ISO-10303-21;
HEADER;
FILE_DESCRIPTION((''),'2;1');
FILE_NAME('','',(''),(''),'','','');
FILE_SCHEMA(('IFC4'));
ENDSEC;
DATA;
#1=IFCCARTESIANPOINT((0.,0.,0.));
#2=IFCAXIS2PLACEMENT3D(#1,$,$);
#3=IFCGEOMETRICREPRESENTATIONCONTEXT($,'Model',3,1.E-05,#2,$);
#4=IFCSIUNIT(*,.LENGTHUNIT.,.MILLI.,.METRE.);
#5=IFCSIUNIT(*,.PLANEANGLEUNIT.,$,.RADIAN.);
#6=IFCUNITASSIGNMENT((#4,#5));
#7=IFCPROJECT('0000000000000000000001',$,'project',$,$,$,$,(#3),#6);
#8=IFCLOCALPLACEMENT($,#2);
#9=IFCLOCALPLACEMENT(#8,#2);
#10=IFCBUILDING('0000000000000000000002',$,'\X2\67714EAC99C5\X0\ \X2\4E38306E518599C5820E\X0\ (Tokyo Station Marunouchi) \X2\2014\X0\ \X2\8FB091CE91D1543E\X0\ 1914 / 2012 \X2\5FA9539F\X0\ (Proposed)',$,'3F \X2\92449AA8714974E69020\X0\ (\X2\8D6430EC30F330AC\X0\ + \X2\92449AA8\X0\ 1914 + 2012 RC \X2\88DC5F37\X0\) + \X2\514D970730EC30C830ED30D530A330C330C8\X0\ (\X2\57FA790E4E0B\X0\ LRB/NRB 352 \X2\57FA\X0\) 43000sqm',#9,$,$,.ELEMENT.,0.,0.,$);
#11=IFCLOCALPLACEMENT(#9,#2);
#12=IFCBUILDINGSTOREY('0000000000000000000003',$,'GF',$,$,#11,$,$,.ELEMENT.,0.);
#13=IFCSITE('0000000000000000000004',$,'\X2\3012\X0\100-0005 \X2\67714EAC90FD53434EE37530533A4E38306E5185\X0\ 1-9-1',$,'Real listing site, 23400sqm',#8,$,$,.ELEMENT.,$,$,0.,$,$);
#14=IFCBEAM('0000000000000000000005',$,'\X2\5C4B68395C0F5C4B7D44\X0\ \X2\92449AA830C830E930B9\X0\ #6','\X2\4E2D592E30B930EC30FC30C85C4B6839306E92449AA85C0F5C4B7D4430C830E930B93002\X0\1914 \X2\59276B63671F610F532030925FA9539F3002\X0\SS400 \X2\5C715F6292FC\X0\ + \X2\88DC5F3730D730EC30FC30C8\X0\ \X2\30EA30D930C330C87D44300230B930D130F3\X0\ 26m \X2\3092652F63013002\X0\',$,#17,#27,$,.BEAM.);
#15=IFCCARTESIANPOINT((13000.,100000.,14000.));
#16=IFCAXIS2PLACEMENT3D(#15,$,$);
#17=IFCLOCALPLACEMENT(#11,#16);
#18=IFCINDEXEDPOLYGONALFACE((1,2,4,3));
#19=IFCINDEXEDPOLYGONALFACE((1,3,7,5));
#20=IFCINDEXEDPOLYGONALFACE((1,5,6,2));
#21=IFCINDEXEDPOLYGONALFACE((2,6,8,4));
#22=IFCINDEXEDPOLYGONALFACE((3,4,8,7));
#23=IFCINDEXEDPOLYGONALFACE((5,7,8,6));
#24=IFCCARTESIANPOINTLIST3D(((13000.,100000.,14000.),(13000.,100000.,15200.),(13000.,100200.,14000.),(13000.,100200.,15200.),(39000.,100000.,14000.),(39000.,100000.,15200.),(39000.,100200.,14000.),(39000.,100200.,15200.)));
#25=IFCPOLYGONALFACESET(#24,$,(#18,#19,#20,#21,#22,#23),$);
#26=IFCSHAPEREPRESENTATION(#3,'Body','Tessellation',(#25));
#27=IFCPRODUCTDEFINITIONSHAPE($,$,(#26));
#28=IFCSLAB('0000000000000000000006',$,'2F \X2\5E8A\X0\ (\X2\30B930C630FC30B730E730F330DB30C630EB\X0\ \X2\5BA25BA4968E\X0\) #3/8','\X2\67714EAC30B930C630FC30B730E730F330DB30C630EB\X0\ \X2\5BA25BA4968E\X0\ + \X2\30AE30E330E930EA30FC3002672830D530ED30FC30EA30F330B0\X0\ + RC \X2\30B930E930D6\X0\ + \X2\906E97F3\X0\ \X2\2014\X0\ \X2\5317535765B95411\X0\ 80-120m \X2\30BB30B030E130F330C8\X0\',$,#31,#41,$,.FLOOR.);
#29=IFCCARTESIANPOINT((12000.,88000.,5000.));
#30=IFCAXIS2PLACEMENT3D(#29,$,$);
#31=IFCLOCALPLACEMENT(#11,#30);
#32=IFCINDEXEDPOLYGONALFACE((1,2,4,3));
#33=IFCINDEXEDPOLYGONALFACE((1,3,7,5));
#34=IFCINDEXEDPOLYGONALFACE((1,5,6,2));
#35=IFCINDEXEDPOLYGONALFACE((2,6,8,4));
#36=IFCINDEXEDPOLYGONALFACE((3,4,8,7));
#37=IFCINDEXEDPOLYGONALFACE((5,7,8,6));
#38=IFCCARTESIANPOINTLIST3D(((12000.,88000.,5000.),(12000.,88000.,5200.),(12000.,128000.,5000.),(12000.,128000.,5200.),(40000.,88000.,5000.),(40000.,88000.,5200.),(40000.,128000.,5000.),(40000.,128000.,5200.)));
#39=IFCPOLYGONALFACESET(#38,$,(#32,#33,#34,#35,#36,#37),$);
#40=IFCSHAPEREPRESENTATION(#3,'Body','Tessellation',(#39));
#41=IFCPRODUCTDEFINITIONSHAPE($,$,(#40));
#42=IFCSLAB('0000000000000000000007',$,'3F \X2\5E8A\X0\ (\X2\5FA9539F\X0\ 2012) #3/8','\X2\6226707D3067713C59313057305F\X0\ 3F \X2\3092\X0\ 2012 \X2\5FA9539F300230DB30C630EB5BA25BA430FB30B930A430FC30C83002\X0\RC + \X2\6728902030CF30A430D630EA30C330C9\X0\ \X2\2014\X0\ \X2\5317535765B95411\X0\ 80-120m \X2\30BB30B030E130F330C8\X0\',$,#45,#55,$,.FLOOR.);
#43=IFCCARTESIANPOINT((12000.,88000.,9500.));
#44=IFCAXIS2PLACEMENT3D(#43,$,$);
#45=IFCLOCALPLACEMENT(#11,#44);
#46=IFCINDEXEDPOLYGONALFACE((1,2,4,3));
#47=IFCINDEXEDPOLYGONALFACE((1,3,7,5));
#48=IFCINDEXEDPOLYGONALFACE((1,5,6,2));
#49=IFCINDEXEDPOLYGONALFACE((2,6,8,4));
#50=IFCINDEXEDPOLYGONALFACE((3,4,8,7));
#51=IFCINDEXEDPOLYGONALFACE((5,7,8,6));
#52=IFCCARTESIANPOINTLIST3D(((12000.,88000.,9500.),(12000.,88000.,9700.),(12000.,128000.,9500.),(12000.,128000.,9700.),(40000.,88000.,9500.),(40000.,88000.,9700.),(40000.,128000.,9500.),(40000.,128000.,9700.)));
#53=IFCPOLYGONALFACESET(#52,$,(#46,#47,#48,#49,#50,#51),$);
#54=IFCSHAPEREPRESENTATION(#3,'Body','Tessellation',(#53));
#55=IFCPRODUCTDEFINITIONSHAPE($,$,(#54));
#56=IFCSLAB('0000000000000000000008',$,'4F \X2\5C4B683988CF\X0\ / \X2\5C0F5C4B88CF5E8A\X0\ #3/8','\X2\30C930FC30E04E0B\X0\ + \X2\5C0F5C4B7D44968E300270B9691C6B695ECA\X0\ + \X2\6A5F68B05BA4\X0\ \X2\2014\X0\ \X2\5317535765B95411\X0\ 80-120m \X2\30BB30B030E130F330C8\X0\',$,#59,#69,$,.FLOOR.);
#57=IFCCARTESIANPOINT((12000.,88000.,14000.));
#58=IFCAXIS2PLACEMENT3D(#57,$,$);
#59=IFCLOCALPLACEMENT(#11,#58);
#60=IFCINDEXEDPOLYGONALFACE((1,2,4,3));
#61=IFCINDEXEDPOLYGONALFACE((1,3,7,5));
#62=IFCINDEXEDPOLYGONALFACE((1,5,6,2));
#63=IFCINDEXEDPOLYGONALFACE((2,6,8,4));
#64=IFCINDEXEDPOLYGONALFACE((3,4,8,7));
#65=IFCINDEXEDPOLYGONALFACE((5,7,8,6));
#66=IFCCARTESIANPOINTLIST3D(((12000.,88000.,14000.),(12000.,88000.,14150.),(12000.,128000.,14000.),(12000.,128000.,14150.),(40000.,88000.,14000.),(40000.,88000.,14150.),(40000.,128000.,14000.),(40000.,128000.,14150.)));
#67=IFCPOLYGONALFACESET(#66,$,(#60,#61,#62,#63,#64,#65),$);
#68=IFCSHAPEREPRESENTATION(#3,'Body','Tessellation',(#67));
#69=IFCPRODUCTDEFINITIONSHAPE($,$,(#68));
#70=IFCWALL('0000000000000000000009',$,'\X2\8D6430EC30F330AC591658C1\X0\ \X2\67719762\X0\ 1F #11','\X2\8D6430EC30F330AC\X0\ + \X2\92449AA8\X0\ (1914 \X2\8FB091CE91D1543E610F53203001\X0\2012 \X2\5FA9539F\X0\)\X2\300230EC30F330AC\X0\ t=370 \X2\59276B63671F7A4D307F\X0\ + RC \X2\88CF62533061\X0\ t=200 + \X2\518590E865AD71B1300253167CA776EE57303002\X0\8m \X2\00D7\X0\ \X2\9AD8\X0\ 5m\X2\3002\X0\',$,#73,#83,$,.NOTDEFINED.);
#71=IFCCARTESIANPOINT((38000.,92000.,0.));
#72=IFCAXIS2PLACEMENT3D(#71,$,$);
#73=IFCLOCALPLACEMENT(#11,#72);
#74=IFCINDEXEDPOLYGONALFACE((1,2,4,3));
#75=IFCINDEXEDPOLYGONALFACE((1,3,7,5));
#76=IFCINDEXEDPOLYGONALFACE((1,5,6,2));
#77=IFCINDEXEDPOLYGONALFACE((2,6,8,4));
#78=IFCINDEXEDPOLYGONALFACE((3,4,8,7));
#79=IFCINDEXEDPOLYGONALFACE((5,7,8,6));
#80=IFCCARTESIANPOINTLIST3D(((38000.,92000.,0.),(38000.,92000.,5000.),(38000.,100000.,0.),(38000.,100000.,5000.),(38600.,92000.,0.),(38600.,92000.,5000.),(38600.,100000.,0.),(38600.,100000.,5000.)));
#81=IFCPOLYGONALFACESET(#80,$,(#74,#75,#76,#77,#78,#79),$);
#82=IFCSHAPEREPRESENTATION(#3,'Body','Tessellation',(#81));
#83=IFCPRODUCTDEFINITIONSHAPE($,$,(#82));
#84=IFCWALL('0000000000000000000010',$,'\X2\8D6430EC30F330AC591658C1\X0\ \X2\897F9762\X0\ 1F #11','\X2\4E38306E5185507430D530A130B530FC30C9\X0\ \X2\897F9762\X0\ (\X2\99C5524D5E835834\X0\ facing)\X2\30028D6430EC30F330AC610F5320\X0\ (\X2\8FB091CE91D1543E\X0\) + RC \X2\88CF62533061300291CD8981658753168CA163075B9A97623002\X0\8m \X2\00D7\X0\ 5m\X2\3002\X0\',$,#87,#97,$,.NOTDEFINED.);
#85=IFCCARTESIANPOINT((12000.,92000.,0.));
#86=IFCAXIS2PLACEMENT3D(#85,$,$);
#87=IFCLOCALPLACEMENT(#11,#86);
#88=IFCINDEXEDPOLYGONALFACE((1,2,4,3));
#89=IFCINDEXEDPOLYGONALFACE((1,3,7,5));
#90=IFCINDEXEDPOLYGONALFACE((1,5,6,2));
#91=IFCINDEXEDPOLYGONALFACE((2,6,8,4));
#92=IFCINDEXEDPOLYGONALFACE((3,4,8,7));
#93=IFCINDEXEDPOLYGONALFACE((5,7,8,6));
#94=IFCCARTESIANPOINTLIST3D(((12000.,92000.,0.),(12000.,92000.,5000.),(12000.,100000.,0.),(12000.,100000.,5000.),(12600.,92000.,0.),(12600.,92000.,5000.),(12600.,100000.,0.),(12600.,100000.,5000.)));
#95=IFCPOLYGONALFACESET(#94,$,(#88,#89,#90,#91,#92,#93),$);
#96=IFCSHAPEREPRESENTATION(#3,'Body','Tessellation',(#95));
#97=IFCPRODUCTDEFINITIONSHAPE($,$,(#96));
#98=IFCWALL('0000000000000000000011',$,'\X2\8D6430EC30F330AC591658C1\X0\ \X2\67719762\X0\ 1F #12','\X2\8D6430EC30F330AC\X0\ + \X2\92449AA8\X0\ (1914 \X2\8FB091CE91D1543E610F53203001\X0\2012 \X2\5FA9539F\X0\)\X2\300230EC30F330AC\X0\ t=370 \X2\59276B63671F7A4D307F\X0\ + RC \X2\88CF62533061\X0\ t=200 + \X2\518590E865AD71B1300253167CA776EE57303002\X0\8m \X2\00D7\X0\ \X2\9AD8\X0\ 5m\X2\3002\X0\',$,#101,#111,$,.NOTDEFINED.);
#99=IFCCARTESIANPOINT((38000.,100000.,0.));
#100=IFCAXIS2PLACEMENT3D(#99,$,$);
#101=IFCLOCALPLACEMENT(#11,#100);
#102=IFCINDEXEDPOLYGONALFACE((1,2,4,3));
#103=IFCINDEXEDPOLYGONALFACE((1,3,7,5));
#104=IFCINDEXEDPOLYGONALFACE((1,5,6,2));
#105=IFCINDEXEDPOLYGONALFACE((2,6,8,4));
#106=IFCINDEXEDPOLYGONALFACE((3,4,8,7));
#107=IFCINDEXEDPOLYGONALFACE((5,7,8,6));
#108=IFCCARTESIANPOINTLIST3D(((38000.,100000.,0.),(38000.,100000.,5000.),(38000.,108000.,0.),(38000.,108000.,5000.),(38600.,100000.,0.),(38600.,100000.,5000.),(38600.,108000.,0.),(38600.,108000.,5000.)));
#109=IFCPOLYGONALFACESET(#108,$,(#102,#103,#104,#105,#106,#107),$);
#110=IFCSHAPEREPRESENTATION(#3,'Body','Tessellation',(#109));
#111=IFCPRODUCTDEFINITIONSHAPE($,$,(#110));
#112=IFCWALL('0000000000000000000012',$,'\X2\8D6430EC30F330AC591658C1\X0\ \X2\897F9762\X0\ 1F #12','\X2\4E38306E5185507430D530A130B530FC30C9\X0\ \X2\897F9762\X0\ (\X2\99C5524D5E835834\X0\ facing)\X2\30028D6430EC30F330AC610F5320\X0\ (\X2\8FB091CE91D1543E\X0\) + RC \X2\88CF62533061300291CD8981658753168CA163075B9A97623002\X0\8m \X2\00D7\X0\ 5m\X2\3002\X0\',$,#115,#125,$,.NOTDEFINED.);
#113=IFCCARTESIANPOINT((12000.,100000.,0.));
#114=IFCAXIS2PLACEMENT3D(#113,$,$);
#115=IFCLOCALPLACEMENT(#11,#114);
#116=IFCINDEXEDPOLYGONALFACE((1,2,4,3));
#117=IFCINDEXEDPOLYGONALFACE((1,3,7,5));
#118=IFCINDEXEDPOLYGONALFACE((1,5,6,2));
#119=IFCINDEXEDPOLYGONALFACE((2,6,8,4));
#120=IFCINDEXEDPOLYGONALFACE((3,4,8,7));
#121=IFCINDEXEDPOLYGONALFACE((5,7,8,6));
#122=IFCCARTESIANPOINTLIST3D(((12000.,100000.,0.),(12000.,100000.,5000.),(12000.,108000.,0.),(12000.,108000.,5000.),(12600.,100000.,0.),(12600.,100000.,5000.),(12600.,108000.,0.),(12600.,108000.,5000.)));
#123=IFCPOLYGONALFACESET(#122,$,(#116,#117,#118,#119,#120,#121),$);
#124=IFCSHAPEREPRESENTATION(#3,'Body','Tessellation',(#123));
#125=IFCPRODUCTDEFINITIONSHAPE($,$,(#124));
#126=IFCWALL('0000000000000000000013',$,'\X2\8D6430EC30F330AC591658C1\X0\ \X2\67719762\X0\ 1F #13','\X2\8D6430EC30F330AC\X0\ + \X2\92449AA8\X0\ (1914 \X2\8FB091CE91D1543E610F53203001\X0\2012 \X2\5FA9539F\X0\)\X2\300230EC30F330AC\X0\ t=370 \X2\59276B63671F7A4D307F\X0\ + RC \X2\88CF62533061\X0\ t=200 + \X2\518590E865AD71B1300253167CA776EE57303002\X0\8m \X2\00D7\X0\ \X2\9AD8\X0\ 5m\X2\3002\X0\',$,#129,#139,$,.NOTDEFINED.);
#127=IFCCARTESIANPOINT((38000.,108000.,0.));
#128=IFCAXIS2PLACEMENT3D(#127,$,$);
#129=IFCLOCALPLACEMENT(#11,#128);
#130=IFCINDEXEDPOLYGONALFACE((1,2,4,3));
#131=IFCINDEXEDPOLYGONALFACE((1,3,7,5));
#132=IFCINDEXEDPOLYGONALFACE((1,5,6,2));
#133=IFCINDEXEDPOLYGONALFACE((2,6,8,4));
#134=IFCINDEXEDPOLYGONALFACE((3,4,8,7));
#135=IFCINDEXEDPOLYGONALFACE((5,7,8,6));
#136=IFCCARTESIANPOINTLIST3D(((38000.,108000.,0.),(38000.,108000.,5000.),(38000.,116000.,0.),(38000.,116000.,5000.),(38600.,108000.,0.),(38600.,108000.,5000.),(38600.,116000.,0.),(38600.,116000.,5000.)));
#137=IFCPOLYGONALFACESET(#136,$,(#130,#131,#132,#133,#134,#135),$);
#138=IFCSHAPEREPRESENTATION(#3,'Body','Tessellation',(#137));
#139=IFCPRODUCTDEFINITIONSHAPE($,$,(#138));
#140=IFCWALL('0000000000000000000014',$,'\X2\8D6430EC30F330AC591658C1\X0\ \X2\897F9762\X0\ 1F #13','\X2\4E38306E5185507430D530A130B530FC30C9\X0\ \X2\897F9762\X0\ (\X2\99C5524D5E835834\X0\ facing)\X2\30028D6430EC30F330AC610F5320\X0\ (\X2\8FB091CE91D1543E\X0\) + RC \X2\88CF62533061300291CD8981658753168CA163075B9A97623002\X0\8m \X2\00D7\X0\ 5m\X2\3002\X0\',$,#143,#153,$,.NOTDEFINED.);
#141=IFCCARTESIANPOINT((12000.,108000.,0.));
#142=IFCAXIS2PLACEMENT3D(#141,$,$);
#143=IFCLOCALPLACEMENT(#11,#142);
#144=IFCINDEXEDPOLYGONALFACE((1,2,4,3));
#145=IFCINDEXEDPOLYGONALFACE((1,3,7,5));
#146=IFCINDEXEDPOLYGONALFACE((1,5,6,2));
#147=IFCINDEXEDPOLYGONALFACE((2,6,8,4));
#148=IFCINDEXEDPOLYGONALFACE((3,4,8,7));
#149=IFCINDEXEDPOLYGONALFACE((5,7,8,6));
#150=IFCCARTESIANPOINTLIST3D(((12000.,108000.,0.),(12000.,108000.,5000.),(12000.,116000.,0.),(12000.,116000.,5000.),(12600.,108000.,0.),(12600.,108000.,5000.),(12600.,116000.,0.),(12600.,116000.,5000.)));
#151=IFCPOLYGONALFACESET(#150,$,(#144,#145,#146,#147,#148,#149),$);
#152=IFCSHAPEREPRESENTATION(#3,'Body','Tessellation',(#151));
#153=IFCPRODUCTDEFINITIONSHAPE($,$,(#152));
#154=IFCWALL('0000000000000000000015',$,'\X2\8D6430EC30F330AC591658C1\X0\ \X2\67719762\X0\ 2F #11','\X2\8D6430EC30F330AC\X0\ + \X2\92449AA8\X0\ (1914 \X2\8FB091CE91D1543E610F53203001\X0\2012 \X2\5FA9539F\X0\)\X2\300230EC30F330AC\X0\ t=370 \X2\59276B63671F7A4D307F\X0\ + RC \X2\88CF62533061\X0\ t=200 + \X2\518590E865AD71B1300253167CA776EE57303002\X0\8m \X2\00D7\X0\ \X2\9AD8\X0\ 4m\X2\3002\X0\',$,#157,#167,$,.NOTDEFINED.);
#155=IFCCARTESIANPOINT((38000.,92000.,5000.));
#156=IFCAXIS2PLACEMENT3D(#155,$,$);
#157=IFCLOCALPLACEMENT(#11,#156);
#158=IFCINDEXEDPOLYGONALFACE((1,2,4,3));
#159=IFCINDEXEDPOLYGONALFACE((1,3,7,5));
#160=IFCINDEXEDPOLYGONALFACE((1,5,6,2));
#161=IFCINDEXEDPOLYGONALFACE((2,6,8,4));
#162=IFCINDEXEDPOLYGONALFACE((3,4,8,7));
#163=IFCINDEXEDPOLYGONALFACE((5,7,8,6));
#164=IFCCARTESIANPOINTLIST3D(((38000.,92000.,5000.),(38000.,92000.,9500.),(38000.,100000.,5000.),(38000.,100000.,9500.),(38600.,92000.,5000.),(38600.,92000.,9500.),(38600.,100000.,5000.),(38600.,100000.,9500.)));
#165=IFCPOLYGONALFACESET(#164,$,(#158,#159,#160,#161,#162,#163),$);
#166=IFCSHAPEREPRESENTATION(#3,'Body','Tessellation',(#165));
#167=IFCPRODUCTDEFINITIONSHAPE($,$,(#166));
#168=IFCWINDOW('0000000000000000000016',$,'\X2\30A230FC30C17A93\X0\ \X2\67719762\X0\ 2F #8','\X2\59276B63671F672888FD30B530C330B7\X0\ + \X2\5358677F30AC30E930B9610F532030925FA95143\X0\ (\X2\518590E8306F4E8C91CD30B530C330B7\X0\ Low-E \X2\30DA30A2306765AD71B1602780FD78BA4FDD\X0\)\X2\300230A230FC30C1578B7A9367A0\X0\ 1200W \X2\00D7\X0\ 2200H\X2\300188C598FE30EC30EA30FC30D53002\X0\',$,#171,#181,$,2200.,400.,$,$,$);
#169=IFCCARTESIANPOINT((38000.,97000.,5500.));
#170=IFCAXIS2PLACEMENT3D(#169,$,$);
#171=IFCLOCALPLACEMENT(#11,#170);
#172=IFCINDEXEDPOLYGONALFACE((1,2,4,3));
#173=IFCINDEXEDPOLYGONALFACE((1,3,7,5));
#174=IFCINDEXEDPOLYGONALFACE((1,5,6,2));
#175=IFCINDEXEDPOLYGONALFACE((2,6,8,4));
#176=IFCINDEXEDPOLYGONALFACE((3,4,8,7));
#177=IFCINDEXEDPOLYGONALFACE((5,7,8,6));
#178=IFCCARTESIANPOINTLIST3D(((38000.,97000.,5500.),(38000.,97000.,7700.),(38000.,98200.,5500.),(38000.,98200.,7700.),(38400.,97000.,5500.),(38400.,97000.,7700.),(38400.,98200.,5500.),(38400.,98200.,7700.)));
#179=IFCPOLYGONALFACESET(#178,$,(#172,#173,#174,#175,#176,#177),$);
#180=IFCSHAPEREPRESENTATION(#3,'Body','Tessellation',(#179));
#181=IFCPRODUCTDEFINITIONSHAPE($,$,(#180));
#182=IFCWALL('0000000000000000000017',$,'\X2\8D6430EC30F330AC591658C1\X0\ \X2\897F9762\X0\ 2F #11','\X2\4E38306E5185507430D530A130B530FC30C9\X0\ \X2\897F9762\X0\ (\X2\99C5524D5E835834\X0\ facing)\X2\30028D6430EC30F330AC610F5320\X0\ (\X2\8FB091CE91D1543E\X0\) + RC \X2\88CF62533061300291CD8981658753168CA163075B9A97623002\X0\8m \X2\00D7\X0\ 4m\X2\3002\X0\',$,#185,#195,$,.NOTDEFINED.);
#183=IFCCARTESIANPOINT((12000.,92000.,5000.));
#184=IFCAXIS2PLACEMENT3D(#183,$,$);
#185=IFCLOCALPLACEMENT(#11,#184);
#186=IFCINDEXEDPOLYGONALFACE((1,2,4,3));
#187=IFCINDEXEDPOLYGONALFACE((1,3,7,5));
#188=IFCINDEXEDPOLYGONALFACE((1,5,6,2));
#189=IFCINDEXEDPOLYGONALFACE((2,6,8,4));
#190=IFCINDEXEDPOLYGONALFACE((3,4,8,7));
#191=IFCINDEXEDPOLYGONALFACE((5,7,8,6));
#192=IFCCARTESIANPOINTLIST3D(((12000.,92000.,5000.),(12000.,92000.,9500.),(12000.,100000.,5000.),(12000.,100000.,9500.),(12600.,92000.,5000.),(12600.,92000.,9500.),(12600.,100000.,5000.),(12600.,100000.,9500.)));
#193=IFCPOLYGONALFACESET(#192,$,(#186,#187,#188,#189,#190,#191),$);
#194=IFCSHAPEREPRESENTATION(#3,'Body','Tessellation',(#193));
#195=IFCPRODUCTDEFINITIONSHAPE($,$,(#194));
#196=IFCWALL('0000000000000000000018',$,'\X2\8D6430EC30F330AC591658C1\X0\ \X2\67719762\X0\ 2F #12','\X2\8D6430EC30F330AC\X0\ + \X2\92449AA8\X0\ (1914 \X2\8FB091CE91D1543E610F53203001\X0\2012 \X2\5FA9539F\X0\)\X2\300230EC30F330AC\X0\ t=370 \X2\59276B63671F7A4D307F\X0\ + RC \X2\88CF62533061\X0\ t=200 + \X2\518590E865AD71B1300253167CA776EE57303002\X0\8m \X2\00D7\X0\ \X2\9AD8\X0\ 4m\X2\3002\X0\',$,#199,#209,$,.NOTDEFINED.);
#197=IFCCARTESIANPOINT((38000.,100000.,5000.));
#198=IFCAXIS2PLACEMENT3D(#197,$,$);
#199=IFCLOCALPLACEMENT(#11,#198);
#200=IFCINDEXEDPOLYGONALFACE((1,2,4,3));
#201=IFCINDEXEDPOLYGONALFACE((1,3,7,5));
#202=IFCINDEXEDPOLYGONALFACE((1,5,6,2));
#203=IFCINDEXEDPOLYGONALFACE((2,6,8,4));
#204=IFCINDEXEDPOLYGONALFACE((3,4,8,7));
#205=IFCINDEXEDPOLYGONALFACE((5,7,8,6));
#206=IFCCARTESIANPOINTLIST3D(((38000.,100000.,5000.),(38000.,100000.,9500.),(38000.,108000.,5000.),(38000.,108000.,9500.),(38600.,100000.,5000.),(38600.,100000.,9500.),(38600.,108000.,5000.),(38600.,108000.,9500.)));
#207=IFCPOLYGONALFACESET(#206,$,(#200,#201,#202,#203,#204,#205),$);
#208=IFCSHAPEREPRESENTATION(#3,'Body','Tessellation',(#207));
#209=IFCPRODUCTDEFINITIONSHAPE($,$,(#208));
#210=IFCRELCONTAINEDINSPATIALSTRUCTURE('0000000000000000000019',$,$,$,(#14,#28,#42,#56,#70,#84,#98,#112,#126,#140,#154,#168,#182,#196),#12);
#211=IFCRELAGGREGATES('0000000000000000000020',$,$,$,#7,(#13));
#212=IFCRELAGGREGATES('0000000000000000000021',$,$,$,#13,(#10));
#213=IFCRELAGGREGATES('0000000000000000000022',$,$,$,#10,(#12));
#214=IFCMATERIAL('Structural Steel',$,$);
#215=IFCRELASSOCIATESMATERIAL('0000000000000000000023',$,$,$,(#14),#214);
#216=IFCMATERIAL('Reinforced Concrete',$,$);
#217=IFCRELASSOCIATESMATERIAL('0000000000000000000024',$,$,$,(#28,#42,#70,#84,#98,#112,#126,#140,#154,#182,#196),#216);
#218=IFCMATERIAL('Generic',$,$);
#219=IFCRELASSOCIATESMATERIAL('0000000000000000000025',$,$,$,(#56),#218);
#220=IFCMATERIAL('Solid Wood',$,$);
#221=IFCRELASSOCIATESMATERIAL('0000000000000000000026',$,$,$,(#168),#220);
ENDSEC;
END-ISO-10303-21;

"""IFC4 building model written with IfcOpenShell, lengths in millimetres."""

from ifc_helpers import new_model, si_unit, frame, frame_2d, origin, place, context, project, spatial, rectangle, extrude, material, element, fill, save


model = new_model("IFC4")

# Units and contexts
model_context = context("Model", 3, precision=1e-05, world=origin())
ifc_project = project(units=[si_unit("LENGTHUNIT", "METRE", prefix="MILLI"), si_unit("PLANEANGLEUNIT", "RADIAN")], contexts=[model_context])

# Site, building, storey
site_placement = place(None, origin())
site = spatial("IfcSite", under=ifc_project, at=site_placement, Name="〒100-0005 東京都千代田区丸の内 1-9-1", ObjectType="Real listing site, 23400sqm", CompositionType="ELEMENT", RefElevation=0.0)
building_placement = place(site_placement, origin())
building = spatial("IfcBuilding", under=site, at=building_placement, Name="東京駅 丸の内駅舎 (Tokyo Station Marunouchi) — 辰野金吾 1914 / 2012 復原 (Proposed)", ObjectType="3F 鉄骨煉瓦造 (赤レンガ + 鉄骨 1914 + 2012 RC 補強) + 免震レトロフィット (基礎下 LRB/NRB 352 基) 43000sqm", CompositionType="ELEMENT", ElevationOfRefHeight=0.0, ElevationOfTerrain=0.0)
storey_placement = place(building_placement, origin())
storey = spatial("IfcBuildingStorey", under=building, at=storey_placement, Name="GF", CompositionType="ELEMENT", Elevation=0.0)

# Beam
ifc_material_1 = material(Name="Structural Steel")
beam_placement = place(storey_placement, frame((13000.0, 100000.0, 14000.0)))
element("IfcBeam", 1, at=beam_placement, inside=storey, material=ifc_material_1, Name="屋根小屋組 鉄骨トラス #6", Description="中央スレート屋根の鉄骨小屋組トラス。1914 大正期意匠を復原。SS400 山形鋼 + 補強プレート リベット組。スパン 26m を支持。", PredefinedType="BEAM", context=model_context, shape_type="SweptSolid", body=[
    extrude(rectangle(XDim=26000.0, YDim=200.0, at=frame_2d((13000.0, 100.0))), frame((13000.0, 100000.0, 14000.0)), (0.0, 0.0, 1.0), 1200.0),
])

# Slabs
ifc_material_2 = material(Name="Reinforced Concrete")
slab_1_placement = place(storey_placement, frame((12000.0, 88000.0, 5000.0)))
element("IfcSlab", 2, at=slab_1_placement, inside=storey, material=ifc_material_2, Name="2F 床 (ステーションホテル 客室階) #3/8", Description="東京ステーションホテル 客室階 + ギャラリー。木フローリング + RC スラブ + 遮音 — 北南方向 80-120m セグメント", PredefinedType="FLOOR", context=model_context, shape_type="SweptSolid", body=[
    extrude(rectangle(XDim=28000.0, YDim=40000.0, at=frame_2d((14000.0, 20000.0))), frame((12000.0, 88000.0, 5000.0)), (0.0, 0.0, 1.0), 200.0),
])
slab_2_placement = place(storey_placement, frame((12000.0, 88000.0, 9500.0)))
element("IfcSlab", 3, at=slab_2_placement, inside=storey, material=ifc_material_2, Name="3F 床 (復原 2012) #3/8", Description="戦災で焼失した 3F を 2012 復原。ホテル客室・スイート。RC + 木造ハイブリッド — 北南方向 80-120m セグメント", PredefinedType="FLOOR", context=model_context, shape_type="SweptSolid", body=[
    extrude(rectangle(XDim=28000.0, YDim=40000.0, at=frame_2d((14000.0, 20000.0))), frame((12000.0, 88000.0, 9500.0)), (0.0, 0.0, 1.0), 200.0),
])
ifc_material_3 = material(Name="Generic")
slab_3_placement = place(storey_placement, frame((12000.0, 88000.0, 14000.0)))
element("IfcSlab", 4, at=slab_3_placement, inside=storey, material=ifc_material_3, Name="4F 屋根裏 / 小屋裏床 #3/8", Description="ドーム下 + 小屋組階。点検歩廊 + 機械室 — 北南方向 80-120m セグメント", PredefinedType="FLOOR", context=model_context, shape_type="SweptSolid", body=[
    extrude(rectangle(XDim=28000.0, YDim=40000.0, at=frame_2d((14000.0, 20000.0))), frame((12000.0, 88000.0, 14000.0)), (0.0, 0.0, 1.0), 150.0),
])

# Walls
wall_1_placement = place(storey_placement, frame((38000.0, 92000.0, 0.0)))
element("IfcWall", 5, at=wall_1_placement, inside=storey, material=ifc_material_2, Name="赤レンガ外壁 東面 1F #11", Description="赤レンガ + 鉄骨 (1914 辰野金吾意匠、2012 復原)。レンガ t=370 大正期積み + RC 裏打ち t=200 + 内部断熱。化粧目地。8m × 高 5m。", PredefinedType="NOTDEFINED", context=model_context, shape_type="SweptSolid", body=[
    extrude(rectangle(XDim=600.0, YDim=8000.0, at=frame_2d((300.0, 4000.0))), frame((38000.0, 92000.0, 0.0)), (0.0, 0.0, 1.0), 5000.0),
])
wall_2_placement = place(storey_placement, frame((12000.0, 92000.0, 0.0)))
element("IfcWall", 6, at=wall_2_placement, inside=storey, material=ifc_material_2, Name="赤レンガ外壁 西面 1F #11", Description="丸の内側ファサード 西面 (駅前広場 facing)。赤レンガ意匠 (辰野金吾) + RC 裏打ち。重要文化財指定面。8m × 5m。", PredefinedType="NOTDEFINED", context=model_context, shape_type="SweptSolid", body=[
    extrude(rectangle(XDim=600.0, YDim=8000.0, at=frame_2d((300.0, 4000.0))), frame((12000.0, 92000.0, 0.0)), (0.0, 0.0, 1.0), 5000.0),
])
wall_3_placement = place(storey_placement, frame((38000.0, 100000.0, 0.0)))
element("IfcWall", 7, at=wall_3_placement, inside=storey, material=ifc_material_2, Name="赤レンガ外壁 東面 1F #12", Description="赤レンガ + 鉄骨 (1914 辰野金吾意匠、2012 復原)。レンガ t=370 大正期積み + RC 裏打ち t=200 + 内部断熱。化粧目地。8m × 高 5m。", PredefinedType="NOTDEFINED", context=model_context, shape_type="SweptSolid", body=[
    extrude(rectangle(XDim=600.0, YDim=8000.0, at=frame_2d((300.0, 4000.0))), frame((38000.0, 100000.0, 0.0)), (0.0, 0.0, 1.0), 5000.0),
])
wall_4_placement = place(storey_placement, frame((12000.0, 100000.0, 0.0)))
element("IfcWall", 8, at=wall_4_placement, inside=storey, material=ifc_material_2, Name="赤レンガ外壁 西面 1F #12", Description="丸の内側ファサード 西面 (駅前広場 facing)。赤レンガ意匠 (辰野金吾) + RC 裏打ち。重要文化財指定面。8m × 5m。", PredefinedType="NOTDEFINED", context=model_context, shape_type="SweptSolid", body=[
    extrude(rectangle(XDim=600.0, YDim=8000.0, at=frame_2d((300.0, 4000.0))), frame((12000.0, 100000.0, 0.0)), (0.0, 0.0, 1.0), 5000.0),
])
wall_5_placement = place(storey_placement, frame((38000.0, 108000.0, 0.0)))
element("IfcWall", 9, at=wall_5_placement, inside=storey, material=ifc_material_2, Name="赤レンガ外壁 東面 1F #13", Description="赤レンガ + 鉄骨 (1914 辰野金吾意匠、2012 復原)。レンガ t=370 大正期積み + RC 裏打ち t=200 + 内部断熱。化粧目地。8m × 高 5m。", PredefinedType="NOTDEFINED", context=model_context, shape_type="SweptSolid", body=[
    extrude(rectangle(XDim=600.0, YDim=8000.0, at=frame_2d((300.0, 4000.0))), frame((38000.0, 108000.0, 0.0)), (0.0, 0.0, 1.0), 5000.0),
])
wall_6_placement = place(storey_placement, frame((12000.0, 108000.0, 0.0)))
element("IfcWall", 10, at=wall_6_placement, inside=storey, material=ifc_material_2, Name="赤レンガ外壁 西面 1F #13", Description="丸の内側ファサード 西面 (駅前広場 facing)。赤レンガ意匠 (辰野金吾) + RC 裏打ち。重要文化財指定面。8m × 5m。", PredefinedType="NOTDEFINED", context=model_context, shape_type="SweptSolid", body=[
    extrude(rectangle(XDim=600.0, YDim=8000.0, at=frame_2d((300.0, 4000.0))), frame((12000.0, 108000.0, 0.0)), (0.0, 0.0, 1.0), 5000.0),
])

# Wall, opening, window
wall_7_placement = place(storey_placement, frame((38000.0, 92000.0, 5000.0)))
wall_7 = element("IfcWall", 11, at=wall_7_placement, inside=storey, material=ifc_material_2, Name="赤レンガ外壁 東面 2F #11", Description="赤レンガ + 鉄骨 (1914 辰野金吾意匠、2012 復原)。レンガ t=370 大正期積み + RC 裏打ち t=200 + 内部断熱。化粧目地。8m × 高 4m。", PredefinedType="NOTDEFINED", context=model_context, shape_type="SweptSolid", body=[
    extrude(rectangle(XDim=600.0, YDim=8000.0, at=frame_2d((300.0, 4000.0))), frame((38000.0, 92000.0, 5000.0)), (0.0, 0.0, 1.0), 4500.0),
])
opening_placement = place(storey_placement, frame((38000.0, 97000.0, 5500.0)))
opening = element("IfcOpeningElement", 12, at=opening_placement, cuts=wall_7, PredefinedType="NOTDEFINED", context=model_context, shape_type="SweptSolid", body=[
    extrude(rectangle(XDim=400.0, YDim=1200.0, at=frame_2d((200.0, 600.0))), frame((38000.0, 97000.0, 5500.0)), (0.0, 0.0, 1.0), 2200.0),
])
ifc_material_4 = material(Name="Solid Wood")
window_1_placement = place(storey_placement, frame((38000.0, 97000.0, 5500.0)))
window_1 = element("IfcWindow", 13, at=window_1_placement, inside=storey, material=ifc_material_4, Name="アーチ窓 東面 2F #8", Description="大正期木製サッシ + 単板ガラス意匠を復元 (内部は二重サッシ Low-E ペアで断熱性能確保)。アーチ型窓枠 1200W × 2200H、装飾レリーフ。", OverallHeight=2200.0, OverallWidth=400.0, context=model_context, shape_type="SweptSolid", body=[
    extrude(rectangle(XDim=400.0, YDim=1200.0, at=frame_2d((200.0, 600.0))), frame((38000.0, 97000.0, 5500.0)), (0.0, 0.0, 1.0), 2200.0),
])
fill(opening, window_1)

# Walls
wall_8_placement = place(storey_placement, frame((12000.0, 92000.0, 5000.0)))
element("IfcWall", 14, at=wall_8_placement, inside=storey, material=ifc_material_2, Name="赤レンガ外壁 西面 2F #11", Description="丸の内側ファサード 西面 (駅前広場 facing)。赤レンガ意匠 (辰野金吾) + RC 裏打ち。重要文化財指定面。8m × 4m。", PredefinedType="NOTDEFINED", context=model_context, shape_type="SweptSolid", body=[
    extrude(rectangle(XDim=600.0, YDim=8000.0, at=frame_2d((300.0, 4000.0))), frame((12000.0, 92000.0, 5000.0)), (0.0, 0.0, 1.0), 4500.0),
])
wall_9_placement = place(storey_placement, frame((38000.0, 100000.0, 5000.0)))
element("IfcWall", 15, at=wall_9_placement, inside=storey, material=ifc_material_2, Name="赤レンガ外壁 東面 2F #12", Description="赤レンガ + 鉄骨 (1914 辰野金吾意匠、2012 復原)。レンガ t=370 大正期積み + RC 裏打ち t=200 + 内部断熱。化粧目地。8m × 高 4m。", PredefinedType="NOTDEFINED", context=model_context, shape_type="SweptSolid", body=[
    extrude(rectangle(XDim=600.0, YDim=8000.0, at=frame_2d((300.0, 4000.0))), frame((38000.0, 100000.0, 5000.0)), (0.0, 0.0, 1.0), 4500.0),
])

save(model, "model.ifc")
